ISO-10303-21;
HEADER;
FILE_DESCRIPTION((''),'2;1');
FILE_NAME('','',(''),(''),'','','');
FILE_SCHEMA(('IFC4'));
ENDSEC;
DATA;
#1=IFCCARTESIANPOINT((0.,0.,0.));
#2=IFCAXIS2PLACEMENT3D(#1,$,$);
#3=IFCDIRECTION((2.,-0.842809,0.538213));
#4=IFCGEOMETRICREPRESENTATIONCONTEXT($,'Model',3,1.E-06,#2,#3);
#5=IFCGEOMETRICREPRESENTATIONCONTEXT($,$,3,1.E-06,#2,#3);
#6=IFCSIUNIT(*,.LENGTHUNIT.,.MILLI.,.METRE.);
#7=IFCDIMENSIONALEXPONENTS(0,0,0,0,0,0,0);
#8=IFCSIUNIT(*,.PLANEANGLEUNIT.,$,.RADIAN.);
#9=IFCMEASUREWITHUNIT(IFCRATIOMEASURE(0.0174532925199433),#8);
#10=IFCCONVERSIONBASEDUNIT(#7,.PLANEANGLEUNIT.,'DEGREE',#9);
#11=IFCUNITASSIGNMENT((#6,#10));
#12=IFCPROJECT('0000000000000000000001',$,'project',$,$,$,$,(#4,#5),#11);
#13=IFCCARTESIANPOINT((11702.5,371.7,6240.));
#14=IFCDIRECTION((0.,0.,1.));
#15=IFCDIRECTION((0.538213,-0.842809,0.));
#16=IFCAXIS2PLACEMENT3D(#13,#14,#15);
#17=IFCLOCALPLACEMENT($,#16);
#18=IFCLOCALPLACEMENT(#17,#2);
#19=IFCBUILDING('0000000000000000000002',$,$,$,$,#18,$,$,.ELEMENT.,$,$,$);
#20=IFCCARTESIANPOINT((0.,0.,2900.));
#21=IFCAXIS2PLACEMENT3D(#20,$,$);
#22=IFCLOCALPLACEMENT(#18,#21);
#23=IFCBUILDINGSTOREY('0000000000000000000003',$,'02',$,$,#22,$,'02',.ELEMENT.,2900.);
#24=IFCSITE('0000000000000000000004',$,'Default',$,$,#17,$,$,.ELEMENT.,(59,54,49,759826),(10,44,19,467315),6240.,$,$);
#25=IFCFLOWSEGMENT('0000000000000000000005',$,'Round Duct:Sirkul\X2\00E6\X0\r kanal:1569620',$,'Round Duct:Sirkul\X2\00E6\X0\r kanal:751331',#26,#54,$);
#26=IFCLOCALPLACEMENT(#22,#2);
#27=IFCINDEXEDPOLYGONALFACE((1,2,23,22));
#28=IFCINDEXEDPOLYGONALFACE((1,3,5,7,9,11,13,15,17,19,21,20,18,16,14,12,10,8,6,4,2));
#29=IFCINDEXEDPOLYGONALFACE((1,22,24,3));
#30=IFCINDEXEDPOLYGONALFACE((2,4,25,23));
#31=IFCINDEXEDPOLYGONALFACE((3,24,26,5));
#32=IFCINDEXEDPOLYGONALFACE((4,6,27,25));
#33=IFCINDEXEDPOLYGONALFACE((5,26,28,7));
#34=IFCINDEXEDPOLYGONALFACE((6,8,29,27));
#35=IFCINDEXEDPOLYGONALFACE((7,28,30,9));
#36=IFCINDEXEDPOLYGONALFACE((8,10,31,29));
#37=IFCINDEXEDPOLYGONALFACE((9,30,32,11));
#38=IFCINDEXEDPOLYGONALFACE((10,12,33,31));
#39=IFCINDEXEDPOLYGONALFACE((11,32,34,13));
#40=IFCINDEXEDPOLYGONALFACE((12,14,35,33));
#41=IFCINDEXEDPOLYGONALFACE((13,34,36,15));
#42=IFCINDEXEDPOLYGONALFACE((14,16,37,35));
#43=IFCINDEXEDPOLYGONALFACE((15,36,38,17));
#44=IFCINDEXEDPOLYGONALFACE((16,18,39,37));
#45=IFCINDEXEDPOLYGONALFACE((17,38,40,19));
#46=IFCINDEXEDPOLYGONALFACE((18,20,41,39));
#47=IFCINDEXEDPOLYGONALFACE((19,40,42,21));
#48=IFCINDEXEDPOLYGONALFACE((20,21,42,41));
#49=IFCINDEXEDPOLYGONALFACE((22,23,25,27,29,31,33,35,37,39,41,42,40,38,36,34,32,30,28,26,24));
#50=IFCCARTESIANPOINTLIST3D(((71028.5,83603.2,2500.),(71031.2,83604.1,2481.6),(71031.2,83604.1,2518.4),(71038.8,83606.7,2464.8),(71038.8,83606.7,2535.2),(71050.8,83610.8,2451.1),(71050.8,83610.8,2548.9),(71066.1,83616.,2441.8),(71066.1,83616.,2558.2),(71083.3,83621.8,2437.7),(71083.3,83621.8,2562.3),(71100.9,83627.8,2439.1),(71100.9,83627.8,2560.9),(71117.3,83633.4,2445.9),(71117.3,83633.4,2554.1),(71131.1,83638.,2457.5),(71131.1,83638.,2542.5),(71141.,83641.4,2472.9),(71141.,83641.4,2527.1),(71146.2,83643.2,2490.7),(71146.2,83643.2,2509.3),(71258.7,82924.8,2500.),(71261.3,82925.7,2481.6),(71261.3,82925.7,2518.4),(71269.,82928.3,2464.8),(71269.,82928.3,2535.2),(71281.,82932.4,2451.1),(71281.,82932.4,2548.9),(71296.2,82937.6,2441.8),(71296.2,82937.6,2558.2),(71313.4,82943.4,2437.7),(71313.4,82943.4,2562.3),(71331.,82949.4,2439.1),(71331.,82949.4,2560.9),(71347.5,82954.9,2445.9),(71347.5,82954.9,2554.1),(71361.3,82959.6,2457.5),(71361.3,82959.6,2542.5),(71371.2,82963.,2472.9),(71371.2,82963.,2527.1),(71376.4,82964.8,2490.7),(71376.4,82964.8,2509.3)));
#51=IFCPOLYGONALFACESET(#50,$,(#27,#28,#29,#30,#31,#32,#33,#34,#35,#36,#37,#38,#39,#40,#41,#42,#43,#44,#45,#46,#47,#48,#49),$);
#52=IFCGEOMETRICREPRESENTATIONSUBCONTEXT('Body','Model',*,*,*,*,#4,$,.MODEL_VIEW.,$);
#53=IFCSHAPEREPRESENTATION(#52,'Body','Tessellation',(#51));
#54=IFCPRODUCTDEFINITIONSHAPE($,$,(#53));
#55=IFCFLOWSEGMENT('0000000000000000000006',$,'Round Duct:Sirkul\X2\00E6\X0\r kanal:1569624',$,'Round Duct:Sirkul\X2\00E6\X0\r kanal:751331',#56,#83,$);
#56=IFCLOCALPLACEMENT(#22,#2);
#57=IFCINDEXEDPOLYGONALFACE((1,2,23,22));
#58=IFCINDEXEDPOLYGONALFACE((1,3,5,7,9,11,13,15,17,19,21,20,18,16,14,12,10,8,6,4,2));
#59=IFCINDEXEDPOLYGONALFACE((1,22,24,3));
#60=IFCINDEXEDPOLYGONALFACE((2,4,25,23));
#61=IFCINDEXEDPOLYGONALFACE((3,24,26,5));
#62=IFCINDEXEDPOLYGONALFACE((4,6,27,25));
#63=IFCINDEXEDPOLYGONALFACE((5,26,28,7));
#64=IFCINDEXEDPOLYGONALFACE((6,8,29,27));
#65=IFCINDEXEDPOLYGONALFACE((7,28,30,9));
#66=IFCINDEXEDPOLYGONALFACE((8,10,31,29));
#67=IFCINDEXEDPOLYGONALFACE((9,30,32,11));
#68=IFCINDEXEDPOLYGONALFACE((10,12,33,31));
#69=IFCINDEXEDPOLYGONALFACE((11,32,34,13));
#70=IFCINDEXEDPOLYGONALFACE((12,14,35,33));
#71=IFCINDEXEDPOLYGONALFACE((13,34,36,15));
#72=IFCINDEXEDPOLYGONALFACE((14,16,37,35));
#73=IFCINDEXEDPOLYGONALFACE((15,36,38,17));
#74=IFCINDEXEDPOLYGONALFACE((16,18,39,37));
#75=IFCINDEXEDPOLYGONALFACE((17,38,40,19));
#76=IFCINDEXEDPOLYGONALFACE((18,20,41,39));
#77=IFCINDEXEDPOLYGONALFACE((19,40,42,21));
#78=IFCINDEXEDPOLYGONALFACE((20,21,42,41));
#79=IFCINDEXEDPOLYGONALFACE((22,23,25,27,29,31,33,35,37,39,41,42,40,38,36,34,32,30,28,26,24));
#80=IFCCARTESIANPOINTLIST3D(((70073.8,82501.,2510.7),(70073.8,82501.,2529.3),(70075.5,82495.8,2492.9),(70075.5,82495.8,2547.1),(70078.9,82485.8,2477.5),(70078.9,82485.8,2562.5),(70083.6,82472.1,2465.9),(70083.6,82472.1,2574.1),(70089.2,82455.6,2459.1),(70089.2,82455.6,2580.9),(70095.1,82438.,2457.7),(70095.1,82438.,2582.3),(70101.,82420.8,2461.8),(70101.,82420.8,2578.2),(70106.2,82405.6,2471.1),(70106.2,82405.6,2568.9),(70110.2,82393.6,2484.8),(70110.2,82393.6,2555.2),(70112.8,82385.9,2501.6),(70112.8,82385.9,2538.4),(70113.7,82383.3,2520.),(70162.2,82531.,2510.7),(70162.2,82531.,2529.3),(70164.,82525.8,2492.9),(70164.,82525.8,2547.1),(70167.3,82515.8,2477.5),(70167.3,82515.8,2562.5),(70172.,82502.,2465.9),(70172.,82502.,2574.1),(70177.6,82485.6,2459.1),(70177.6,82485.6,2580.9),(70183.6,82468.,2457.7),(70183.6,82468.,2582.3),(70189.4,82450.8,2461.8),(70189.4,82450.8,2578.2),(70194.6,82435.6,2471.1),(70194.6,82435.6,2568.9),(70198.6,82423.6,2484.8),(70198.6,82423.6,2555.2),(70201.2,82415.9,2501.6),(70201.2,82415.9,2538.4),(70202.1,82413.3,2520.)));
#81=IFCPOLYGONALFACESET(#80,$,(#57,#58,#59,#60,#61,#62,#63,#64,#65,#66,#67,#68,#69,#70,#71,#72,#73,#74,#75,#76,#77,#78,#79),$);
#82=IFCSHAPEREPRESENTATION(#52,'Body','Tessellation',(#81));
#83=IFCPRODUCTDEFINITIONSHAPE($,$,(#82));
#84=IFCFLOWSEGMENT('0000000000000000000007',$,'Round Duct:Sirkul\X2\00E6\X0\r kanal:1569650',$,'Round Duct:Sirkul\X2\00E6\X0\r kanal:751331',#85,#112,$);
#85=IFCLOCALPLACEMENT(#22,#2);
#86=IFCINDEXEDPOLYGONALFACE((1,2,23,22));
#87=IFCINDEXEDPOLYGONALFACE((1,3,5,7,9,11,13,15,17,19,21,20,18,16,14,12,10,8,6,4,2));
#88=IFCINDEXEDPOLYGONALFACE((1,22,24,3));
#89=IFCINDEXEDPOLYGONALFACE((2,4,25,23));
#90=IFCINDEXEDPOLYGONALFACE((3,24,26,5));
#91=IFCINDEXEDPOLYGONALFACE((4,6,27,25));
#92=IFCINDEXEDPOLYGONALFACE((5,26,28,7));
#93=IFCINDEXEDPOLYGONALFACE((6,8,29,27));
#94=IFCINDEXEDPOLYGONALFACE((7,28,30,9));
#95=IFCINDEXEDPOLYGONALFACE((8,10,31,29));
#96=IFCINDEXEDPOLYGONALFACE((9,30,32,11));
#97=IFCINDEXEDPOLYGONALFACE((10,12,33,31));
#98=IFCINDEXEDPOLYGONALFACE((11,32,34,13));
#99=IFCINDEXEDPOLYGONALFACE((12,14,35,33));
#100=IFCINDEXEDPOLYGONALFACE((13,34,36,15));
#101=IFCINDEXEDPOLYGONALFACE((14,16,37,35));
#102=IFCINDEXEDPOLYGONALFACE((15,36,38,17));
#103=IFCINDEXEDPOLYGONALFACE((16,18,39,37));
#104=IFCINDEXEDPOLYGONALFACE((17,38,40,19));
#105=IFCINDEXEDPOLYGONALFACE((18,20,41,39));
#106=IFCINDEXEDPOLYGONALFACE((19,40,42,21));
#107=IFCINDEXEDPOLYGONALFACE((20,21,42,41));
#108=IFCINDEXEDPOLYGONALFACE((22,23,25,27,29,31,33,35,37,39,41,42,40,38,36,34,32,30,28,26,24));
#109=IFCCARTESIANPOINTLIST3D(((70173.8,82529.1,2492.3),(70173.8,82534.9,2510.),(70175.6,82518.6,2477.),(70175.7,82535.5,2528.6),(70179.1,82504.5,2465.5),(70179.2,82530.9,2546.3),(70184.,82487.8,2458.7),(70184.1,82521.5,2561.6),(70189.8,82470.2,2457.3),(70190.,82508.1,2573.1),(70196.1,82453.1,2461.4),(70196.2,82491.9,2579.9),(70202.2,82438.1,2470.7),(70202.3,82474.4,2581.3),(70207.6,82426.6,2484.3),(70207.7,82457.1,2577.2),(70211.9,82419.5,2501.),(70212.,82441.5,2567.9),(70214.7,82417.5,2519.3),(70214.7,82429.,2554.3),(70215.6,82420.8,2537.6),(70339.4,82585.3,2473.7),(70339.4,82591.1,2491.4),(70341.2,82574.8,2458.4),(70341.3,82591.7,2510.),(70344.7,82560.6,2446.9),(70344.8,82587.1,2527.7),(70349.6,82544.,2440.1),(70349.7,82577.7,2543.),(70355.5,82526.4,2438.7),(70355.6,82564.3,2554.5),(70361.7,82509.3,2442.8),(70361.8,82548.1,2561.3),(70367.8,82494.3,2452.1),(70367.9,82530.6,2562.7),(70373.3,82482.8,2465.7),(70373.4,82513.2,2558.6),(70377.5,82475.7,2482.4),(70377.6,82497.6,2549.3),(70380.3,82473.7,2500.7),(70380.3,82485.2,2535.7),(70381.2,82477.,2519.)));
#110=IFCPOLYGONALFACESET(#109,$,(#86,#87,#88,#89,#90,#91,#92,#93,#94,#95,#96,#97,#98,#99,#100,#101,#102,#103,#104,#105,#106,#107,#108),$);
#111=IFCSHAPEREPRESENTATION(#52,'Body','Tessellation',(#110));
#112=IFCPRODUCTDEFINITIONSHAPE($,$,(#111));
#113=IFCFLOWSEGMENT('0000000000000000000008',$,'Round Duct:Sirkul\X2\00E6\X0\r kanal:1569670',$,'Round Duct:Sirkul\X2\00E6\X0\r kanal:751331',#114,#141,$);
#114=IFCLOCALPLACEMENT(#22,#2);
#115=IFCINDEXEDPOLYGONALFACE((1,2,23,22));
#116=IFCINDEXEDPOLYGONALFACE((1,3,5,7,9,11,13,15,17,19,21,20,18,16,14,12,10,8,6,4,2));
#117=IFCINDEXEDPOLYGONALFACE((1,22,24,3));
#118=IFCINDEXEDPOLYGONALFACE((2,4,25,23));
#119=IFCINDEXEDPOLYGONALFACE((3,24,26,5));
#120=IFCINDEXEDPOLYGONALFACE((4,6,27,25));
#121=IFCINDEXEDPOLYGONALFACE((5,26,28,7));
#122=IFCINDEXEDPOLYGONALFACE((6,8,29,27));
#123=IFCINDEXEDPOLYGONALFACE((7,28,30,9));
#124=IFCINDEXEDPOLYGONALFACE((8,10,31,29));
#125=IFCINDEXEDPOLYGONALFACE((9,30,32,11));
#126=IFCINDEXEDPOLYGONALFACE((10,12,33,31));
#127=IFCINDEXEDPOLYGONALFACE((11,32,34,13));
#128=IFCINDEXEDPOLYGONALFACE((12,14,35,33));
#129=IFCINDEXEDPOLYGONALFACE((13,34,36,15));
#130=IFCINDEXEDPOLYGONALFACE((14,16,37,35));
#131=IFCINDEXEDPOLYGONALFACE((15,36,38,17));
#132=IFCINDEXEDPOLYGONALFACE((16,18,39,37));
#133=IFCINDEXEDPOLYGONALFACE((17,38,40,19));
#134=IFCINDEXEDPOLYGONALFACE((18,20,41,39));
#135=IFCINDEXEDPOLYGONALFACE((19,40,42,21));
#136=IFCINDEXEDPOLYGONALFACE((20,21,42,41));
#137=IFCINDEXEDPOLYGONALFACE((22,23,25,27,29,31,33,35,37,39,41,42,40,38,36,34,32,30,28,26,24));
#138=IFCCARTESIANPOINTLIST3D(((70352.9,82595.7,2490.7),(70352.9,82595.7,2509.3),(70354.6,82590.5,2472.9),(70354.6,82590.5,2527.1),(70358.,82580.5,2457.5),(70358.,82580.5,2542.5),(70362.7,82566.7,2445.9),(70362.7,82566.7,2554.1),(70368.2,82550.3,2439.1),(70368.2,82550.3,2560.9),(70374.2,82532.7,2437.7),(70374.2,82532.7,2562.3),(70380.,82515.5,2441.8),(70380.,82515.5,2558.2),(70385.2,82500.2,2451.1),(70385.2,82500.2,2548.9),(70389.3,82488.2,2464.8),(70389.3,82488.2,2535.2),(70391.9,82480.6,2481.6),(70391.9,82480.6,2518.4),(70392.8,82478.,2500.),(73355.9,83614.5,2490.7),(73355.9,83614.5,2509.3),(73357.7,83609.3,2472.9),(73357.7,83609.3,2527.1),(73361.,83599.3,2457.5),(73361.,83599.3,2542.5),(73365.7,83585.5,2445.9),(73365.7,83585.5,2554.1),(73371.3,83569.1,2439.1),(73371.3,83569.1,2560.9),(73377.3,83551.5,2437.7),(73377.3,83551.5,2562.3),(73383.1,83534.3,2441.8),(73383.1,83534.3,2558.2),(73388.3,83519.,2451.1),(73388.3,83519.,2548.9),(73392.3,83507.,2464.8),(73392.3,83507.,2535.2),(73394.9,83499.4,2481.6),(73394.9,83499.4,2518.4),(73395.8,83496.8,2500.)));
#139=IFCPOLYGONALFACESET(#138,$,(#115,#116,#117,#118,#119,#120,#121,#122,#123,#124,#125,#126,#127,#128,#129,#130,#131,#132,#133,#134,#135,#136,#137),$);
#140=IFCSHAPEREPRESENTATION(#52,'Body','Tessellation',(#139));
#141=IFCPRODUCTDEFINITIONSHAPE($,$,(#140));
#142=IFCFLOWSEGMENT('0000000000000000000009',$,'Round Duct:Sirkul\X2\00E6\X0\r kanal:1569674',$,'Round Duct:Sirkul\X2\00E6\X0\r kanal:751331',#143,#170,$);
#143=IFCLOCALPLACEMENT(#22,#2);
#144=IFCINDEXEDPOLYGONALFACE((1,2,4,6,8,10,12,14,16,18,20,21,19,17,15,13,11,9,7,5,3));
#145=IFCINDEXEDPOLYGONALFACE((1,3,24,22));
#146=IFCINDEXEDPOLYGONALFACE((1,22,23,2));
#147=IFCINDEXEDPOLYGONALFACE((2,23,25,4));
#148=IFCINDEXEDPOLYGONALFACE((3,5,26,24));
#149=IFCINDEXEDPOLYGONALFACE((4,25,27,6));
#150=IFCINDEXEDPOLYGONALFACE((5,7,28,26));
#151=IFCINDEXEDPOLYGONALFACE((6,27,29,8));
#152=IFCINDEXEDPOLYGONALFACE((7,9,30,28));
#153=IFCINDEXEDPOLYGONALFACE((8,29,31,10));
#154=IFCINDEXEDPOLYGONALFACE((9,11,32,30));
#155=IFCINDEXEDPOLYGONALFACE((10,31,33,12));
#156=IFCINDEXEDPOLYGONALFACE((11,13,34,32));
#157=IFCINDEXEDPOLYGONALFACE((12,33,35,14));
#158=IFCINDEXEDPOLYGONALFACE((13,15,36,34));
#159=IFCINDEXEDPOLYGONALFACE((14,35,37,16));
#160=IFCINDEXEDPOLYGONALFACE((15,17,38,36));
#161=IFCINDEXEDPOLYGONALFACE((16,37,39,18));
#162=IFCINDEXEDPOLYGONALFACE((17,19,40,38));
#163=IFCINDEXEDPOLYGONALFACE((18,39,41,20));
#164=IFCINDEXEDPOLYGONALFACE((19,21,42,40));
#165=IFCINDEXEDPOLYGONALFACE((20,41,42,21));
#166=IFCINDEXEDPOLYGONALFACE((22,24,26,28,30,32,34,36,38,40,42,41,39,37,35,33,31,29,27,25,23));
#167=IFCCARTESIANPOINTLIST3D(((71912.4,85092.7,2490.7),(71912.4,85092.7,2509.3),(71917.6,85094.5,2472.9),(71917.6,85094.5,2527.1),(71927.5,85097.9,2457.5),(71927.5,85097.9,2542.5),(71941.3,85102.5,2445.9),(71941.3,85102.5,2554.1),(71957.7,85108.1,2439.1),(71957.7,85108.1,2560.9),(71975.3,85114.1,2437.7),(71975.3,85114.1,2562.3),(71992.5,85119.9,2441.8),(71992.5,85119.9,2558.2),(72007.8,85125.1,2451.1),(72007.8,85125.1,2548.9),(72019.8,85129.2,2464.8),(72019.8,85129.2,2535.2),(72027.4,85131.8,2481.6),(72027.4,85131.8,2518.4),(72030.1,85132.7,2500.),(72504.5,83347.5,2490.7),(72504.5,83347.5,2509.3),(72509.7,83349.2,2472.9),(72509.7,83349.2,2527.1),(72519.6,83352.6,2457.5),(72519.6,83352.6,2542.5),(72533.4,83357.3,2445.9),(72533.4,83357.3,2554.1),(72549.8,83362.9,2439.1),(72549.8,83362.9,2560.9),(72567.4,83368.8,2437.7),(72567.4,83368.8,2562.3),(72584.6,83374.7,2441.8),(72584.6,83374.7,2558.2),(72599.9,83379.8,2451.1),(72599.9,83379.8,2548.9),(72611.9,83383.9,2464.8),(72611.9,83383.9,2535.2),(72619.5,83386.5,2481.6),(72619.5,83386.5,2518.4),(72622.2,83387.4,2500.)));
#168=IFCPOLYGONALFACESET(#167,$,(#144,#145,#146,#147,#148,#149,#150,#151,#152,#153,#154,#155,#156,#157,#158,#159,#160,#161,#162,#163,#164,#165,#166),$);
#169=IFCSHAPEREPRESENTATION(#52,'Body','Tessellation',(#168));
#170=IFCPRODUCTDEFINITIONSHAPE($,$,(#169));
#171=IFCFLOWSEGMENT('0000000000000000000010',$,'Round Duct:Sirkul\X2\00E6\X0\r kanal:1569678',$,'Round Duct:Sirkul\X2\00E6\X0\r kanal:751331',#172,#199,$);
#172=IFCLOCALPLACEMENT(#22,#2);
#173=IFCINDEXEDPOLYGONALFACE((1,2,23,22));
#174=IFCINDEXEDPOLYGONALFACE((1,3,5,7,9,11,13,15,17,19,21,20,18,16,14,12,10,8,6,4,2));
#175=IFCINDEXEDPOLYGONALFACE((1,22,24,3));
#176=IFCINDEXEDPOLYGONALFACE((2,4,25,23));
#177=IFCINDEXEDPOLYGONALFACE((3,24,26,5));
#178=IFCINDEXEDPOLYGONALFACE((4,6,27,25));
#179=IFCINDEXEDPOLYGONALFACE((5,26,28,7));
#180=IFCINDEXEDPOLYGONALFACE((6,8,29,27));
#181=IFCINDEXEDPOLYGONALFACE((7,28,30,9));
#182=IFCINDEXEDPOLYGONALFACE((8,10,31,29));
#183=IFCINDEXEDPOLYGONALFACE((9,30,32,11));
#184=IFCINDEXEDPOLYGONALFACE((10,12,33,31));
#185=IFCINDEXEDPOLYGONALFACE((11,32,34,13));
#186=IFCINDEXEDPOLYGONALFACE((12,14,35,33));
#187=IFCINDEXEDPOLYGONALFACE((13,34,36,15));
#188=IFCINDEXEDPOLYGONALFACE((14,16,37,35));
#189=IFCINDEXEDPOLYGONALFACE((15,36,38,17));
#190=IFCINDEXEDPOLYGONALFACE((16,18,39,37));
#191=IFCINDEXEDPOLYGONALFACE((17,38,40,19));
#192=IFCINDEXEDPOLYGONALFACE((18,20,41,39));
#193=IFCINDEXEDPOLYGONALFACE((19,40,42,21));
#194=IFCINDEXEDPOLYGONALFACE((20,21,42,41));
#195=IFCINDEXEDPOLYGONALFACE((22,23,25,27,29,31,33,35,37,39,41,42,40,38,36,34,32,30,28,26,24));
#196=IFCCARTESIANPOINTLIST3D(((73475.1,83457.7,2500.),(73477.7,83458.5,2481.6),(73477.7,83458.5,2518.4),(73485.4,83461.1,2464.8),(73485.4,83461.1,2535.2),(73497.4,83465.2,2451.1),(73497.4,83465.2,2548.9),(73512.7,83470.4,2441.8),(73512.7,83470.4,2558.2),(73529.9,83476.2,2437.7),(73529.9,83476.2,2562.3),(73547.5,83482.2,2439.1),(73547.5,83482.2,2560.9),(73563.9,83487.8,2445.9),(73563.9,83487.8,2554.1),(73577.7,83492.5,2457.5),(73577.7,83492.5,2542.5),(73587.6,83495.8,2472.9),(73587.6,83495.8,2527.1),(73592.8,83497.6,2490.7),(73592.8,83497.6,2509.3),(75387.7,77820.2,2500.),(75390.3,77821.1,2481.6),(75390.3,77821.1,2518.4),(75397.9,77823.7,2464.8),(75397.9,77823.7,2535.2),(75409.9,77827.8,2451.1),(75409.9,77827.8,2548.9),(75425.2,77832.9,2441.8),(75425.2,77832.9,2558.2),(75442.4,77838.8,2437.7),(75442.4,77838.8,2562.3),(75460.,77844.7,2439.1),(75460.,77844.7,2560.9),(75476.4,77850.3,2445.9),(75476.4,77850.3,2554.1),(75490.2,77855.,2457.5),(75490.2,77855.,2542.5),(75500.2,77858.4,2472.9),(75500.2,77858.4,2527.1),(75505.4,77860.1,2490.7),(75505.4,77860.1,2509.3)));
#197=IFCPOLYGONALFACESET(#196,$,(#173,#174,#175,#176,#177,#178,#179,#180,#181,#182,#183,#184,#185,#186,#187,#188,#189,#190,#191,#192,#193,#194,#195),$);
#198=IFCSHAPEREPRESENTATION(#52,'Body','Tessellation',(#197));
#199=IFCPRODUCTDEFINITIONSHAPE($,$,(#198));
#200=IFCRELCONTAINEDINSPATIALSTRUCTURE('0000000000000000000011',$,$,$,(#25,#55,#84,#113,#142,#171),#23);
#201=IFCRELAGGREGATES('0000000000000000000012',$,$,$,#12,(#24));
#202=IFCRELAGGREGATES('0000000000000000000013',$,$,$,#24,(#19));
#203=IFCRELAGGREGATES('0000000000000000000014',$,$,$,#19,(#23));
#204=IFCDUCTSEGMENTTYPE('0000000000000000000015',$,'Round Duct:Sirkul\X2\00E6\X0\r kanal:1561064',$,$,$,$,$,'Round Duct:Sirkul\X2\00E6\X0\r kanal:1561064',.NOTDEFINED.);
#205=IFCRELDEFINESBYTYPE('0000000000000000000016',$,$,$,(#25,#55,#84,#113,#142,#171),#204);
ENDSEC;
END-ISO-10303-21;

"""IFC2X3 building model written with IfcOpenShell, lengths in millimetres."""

from ifc_helpers import new_model, entity, si_unit, converted_unit, direction, frame, frame_2d, origin, origin_2d_with_axis, place, context, subcontext, project, spatial, circle, extrude, type_object, element, save


model = new_model("IFC2X3")

# Units and contexts
model_context = context("Model", 3, precision=1e-06, world=origin(), true_north=direction((2.0, -0.842809, 0.538213)))
context_of_model = context(None, 3, precision=1e-06, world=origin(), true_north=direction((2.0, -0.842809, 0.538213)))
body_context = subcontext(model_context, "Body", "Model", "MODEL_VIEW")
ifc_project = project(units=[si_unit("LENGTHUNIT", "METRE", prefix="MILLI"), converted_unit("PLANEANGLEUNIT", "DEGREE", entity("IfcRatioMeasure", 0.0174532925199433), si_unit("PLANEANGLEUNIT", "RADIAN"), dimensions=[0, 0, 0, 0, 0, 0, 0])], contexts=[model_context, context_of_model])

# Site, building, storey
site_placement = place(None, frame((11702.5, 371.7, 6240.0), z_axis=(0.0, 0.0, 1.0), x_axis=(0.538213, -0.842809, 0.0)))
site = spatial("IfcSite", under=ifc_project, at=site_placement, Name="Default", CompositionType="ELEMENT", RefLatitude=(59, 54, 49, 759826), RefLongitude=(10, 44, 19, 467315), RefElevation=6240.0)
building_placement = place(site_placement, origin())
building = spatial("IfcBuilding", under=site, at=building_placement, CompositionType="ELEMENT")
storey_placement = place(building_placement, frame((0.0, 0.0, 2900.0)))
storey = spatial("IfcBuildingStorey", under=building, at=storey_placement, Name="02", LongName="02", CompositionType="ELEMENT", Elevation=2900.0)

# Flow segments
duct_segment_type = type_object("IfcDuctSegmentType", Name="Round Duct:Sirkulær kanal:1561064", ElementType="Round Duct:Sirkulær kanal:1561064", PredefinedType="NOTDEFINED")
flow_segment_1_placement = place(storey_placement, origin())
element("IfcFlowSegment", 1, at=flow_segment_1_placement, inside=storey, type_object=duct_segment_type, Name="Round Duct:Sirkulær kanal:1569620", ObjectType="Round Duct:Sirkulær kanal:751331", context=body_context, shape_type="SweptSolid", body=[
    extrude(circle(Radius=62.5, at=frame_2d((0.0, 0.0), x_axis=(1.0, 0.0))), frame((71087.7, 83623.3, 2500.0), z_axis=(0.321274, -0.946986, 0.0), x_axis=(-0.946986, -0.321274, 0.0)), (0.0, 0.0, 1.0), 716.4),
])
flow_segment_2_placement = place(storey_placement, origin())
element("IfcFlowSegment", 2, at=flow_segment_2_placement, inside=storey, type_object=duct_segment_type, Name="Round Duct:Sirkulær kanal:1569624", ObjectType="Round Duct:Sirkulær kanal:751331", context=body_context, shape_type="SweptSolid", body=[
    extrude(circle(Radius=62.5, at=origin_2d_with_axis()), frame((70093.6, 82442.5, 2520.0), z_axis=(0.946986, 0.321274, 0.0), x_axis=(0.321274, -0.946986, 0.0)), (0.0, 0.0, 1.0), 93.4),
])
flow_segment_3_placement = place(storey_placement, origin())
element("IfcFlowSegment", 3, at=flow_segment_3_placement, inside=storey, type_object=duct_segment_type, Name="Round Duct:Sirkulær kanal:1569650", ObjectType="Round Duct:Sirkulær kanal:751331", context=body_context, shape_type="SweptSolid", body=[
    extrude(circle(Radius=62.5, at=frame_2d((0.0, 0.0), x_axis=(1.0, 0.0))), frame((70360.2, 82532.9, 2500.7), z_axis=(-0.941677, -0.319473, 0.105746), x_axis=(0.321274, -0.946986, 0.0)), (0.0, 0.0, 1.0), 175.9),
])
flow_segment_4_placement = place(storey_placement, origin())
element("IfcFlowSegment", 4, at=flow_segment_4_placement, inside=storey, type_object=duct_segment_type, Name="Round Duct:Sirkulær kanal:1569670", ObjectType="Round Duct:Sirkulær kanal:751331", context=body_context, shape_type="SweptSolid", body=[
    extrude(circle(Radius=62.5, at=origin_2d_with_axis()), frame((70372.7, 82537.1, 2500.0), z_axis=(0.946986, 0.321274, 0.0), x_axis=(0.321274, -0.946986, 0.0)), (0.0, 0.0, 1.0), 3171.2),
])
flow_segment_5_placement = place(storey_placement, origin())
element("IfcFlowSegment", 5, at=flow_segment_5_placement, inside=storey, type_object=duct_segment_type, Name="Round Duct:Sirkulær kanal:1569674", ObjectType="Round Duct:Sirkulær kanal:751331", context=body_context, shape_type="SweptSolid", body=[
    extrude(circle(Radius=62.5, at=origin_2d_with_axis()), frame((71970.9, 85112.6, 2500.0), z_axis=(0.321274, -0.946986, 0.0), x_axis=(0.946986, 0.321274, 0.0)), (0.0, 0.0, 1.0), 1842.9),
])
flow_segment_6_placement = place(storey_placement, origin())
element("IfcFlowSegment", 6, at=flow_segment_6_placement, inside=storey, type_object=duct_segment_type, Name="Round Duct:Sirkulær kanal:1569678", ObjectType="Round Duct:Sirkulær kanal:751331", context=body_context, shape_type="SweptSolid", body=[
    extrude(circle(Radius=62.5, at=frame_2d((0.0, 0.0), x_axis=(1.0, 0.0))), frame((73534.3, 83477.7, 2500.0), z_axis=(0.321274, -0.946986, 0.0), x_axis=(-0.946986, -0.321274, 0.0)), (0.0, 0.0, 1.0), 5953.1),
])

save(model, "model.ifc")
